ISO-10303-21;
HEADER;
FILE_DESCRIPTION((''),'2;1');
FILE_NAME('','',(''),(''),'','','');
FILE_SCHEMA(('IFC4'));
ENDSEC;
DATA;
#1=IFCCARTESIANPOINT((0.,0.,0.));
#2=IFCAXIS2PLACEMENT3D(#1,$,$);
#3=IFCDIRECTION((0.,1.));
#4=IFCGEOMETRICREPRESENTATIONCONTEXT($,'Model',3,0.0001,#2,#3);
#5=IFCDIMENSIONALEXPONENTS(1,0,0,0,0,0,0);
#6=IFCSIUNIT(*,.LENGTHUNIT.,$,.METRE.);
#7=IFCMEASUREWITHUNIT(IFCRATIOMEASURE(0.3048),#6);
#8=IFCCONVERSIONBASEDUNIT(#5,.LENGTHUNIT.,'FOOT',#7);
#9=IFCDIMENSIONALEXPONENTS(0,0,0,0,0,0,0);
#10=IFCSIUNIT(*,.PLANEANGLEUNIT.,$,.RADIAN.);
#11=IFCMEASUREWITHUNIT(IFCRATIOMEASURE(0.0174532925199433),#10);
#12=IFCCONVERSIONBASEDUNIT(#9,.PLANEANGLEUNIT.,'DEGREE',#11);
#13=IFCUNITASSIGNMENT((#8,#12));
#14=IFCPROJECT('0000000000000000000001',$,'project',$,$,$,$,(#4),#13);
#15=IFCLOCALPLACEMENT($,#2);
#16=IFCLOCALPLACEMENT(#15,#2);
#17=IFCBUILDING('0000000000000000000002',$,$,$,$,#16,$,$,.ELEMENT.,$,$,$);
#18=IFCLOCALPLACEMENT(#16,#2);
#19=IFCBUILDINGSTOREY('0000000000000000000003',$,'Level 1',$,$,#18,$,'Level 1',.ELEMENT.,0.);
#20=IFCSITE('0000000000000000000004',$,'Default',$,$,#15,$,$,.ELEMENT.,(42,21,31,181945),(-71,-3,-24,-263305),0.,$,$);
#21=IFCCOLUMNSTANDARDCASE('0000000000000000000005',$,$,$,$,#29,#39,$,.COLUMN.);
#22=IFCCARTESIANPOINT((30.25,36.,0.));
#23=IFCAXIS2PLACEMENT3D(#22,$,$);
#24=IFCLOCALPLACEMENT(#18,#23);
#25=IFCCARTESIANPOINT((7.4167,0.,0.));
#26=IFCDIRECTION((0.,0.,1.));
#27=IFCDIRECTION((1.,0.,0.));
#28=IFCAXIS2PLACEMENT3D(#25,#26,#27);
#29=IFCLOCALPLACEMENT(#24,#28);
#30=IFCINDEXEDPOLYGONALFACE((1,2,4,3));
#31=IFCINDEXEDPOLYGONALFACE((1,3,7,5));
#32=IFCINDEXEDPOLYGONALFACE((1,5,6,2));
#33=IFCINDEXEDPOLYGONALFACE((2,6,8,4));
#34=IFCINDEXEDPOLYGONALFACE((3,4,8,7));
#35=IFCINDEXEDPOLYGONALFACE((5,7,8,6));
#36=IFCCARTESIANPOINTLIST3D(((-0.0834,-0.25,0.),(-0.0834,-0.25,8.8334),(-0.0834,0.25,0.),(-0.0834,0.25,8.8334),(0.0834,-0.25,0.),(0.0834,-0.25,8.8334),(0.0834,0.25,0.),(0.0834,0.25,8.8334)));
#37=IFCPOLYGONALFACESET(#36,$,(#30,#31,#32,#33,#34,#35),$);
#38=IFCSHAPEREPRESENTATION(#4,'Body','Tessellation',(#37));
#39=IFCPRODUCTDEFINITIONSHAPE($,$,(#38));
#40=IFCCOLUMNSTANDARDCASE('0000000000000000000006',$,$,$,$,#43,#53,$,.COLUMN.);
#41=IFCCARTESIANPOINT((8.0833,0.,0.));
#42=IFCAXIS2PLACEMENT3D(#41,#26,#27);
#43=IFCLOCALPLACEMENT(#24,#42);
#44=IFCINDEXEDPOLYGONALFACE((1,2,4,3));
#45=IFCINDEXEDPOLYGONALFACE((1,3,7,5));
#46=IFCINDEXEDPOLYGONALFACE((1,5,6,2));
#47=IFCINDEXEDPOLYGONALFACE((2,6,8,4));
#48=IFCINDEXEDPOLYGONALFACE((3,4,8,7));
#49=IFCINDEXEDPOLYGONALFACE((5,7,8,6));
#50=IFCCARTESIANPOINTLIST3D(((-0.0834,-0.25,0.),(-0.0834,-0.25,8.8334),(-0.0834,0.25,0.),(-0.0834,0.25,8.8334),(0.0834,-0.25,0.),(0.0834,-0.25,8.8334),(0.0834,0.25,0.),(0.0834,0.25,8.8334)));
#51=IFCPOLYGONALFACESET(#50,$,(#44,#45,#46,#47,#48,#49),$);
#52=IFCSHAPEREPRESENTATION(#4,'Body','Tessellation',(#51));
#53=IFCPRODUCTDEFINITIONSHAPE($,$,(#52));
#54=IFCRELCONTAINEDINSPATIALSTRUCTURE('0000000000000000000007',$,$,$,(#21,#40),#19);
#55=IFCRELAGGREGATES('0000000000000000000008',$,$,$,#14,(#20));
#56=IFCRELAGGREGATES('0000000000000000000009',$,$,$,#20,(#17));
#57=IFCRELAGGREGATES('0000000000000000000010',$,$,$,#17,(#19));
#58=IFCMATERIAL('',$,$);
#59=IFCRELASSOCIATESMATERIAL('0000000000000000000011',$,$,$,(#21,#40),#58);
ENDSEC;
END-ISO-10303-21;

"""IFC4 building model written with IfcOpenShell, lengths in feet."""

from ifc_helpers import new_model, entity, si_unit, converted_unit, direction, frame, origin, place, context, project, spatial, rectangle, extrude, material, element, save


model = new_model("IFC4")

# Units and contexts
model_context = context("Model", 3, precision=0.0001, world=origin(), true_north=direction((0.0, 1.0)))
ifc_project = project(units=[converted_unit("LENGTHUNIT", "FOOT", entity("IfcRatioMeasure", 0.3048), si_unit("LENGTHUNIT", "METRE"), dimensions=[1, 0, 0, 0, 0, 0, 0]), converted_unit("PLANEANGLEUNIT", "DEGREE", entity("IfcRatioMeasure", 0.0174532925199433), si_unit("PLANEANGLEUNIT", "RADIAN"), dimensions=[0, 0, 0, 0, 0, 0, 0])], contexts=[model_context])

# Site, building, storey
site_placement = place(None, origin())
site = spatial("IfcSite", under=ifc_project, at=site_placement, Name="Default", CompositionType="ELEMENT", RefLatitude=(42, 21, 31, 181945), RefLongitude=(-71, -3, -24, -263305), RefElevation=0.0)
building_placement = place(site_placement, origin())
building = spatial("IfcBuilding", under=site, at=building_placement, CompositionType="ELEMENT")
storey_placement = place(building_placement, origin())
storey = spatial("IfcBuildingStorey", under=building, at=storey_placement, Name="Level 1", LongName="Level 1", CompositionType="ELEMENT", Elevation=0.0)

# Columns
ifc_material_1 = material(Name="")
placement_1 = place(storey_placement, frame((30.25, 36.0, 0.0)))
for number, where, z_axis, x_axis in (
    (1, (7.4167, 0.0, 0.0), (0.0, 0.0, 1.0), (1.0, 0.0, 0.0)),
    (2, (8.0833, 0.0, 0.0), (0.0, 0.0, 1.0), (1.0, 0.0, 0.0)),
):
    element("IfcColumnStandardCase", number, at=place(placement_1, frame(where, z_axis=z_axis, x_axis=x_axis)), inside=storey, material=ifc_material_1, PredefinedType="COLUMN", context=model_context, shape_type="SweptSolid", body=[
        extrude(rectangle(XDim=0.1667, YDim=0.5), origin(), (0.0, 0.0, 1.0), 8.8334),
    ])

save(model, "model.ifc")
